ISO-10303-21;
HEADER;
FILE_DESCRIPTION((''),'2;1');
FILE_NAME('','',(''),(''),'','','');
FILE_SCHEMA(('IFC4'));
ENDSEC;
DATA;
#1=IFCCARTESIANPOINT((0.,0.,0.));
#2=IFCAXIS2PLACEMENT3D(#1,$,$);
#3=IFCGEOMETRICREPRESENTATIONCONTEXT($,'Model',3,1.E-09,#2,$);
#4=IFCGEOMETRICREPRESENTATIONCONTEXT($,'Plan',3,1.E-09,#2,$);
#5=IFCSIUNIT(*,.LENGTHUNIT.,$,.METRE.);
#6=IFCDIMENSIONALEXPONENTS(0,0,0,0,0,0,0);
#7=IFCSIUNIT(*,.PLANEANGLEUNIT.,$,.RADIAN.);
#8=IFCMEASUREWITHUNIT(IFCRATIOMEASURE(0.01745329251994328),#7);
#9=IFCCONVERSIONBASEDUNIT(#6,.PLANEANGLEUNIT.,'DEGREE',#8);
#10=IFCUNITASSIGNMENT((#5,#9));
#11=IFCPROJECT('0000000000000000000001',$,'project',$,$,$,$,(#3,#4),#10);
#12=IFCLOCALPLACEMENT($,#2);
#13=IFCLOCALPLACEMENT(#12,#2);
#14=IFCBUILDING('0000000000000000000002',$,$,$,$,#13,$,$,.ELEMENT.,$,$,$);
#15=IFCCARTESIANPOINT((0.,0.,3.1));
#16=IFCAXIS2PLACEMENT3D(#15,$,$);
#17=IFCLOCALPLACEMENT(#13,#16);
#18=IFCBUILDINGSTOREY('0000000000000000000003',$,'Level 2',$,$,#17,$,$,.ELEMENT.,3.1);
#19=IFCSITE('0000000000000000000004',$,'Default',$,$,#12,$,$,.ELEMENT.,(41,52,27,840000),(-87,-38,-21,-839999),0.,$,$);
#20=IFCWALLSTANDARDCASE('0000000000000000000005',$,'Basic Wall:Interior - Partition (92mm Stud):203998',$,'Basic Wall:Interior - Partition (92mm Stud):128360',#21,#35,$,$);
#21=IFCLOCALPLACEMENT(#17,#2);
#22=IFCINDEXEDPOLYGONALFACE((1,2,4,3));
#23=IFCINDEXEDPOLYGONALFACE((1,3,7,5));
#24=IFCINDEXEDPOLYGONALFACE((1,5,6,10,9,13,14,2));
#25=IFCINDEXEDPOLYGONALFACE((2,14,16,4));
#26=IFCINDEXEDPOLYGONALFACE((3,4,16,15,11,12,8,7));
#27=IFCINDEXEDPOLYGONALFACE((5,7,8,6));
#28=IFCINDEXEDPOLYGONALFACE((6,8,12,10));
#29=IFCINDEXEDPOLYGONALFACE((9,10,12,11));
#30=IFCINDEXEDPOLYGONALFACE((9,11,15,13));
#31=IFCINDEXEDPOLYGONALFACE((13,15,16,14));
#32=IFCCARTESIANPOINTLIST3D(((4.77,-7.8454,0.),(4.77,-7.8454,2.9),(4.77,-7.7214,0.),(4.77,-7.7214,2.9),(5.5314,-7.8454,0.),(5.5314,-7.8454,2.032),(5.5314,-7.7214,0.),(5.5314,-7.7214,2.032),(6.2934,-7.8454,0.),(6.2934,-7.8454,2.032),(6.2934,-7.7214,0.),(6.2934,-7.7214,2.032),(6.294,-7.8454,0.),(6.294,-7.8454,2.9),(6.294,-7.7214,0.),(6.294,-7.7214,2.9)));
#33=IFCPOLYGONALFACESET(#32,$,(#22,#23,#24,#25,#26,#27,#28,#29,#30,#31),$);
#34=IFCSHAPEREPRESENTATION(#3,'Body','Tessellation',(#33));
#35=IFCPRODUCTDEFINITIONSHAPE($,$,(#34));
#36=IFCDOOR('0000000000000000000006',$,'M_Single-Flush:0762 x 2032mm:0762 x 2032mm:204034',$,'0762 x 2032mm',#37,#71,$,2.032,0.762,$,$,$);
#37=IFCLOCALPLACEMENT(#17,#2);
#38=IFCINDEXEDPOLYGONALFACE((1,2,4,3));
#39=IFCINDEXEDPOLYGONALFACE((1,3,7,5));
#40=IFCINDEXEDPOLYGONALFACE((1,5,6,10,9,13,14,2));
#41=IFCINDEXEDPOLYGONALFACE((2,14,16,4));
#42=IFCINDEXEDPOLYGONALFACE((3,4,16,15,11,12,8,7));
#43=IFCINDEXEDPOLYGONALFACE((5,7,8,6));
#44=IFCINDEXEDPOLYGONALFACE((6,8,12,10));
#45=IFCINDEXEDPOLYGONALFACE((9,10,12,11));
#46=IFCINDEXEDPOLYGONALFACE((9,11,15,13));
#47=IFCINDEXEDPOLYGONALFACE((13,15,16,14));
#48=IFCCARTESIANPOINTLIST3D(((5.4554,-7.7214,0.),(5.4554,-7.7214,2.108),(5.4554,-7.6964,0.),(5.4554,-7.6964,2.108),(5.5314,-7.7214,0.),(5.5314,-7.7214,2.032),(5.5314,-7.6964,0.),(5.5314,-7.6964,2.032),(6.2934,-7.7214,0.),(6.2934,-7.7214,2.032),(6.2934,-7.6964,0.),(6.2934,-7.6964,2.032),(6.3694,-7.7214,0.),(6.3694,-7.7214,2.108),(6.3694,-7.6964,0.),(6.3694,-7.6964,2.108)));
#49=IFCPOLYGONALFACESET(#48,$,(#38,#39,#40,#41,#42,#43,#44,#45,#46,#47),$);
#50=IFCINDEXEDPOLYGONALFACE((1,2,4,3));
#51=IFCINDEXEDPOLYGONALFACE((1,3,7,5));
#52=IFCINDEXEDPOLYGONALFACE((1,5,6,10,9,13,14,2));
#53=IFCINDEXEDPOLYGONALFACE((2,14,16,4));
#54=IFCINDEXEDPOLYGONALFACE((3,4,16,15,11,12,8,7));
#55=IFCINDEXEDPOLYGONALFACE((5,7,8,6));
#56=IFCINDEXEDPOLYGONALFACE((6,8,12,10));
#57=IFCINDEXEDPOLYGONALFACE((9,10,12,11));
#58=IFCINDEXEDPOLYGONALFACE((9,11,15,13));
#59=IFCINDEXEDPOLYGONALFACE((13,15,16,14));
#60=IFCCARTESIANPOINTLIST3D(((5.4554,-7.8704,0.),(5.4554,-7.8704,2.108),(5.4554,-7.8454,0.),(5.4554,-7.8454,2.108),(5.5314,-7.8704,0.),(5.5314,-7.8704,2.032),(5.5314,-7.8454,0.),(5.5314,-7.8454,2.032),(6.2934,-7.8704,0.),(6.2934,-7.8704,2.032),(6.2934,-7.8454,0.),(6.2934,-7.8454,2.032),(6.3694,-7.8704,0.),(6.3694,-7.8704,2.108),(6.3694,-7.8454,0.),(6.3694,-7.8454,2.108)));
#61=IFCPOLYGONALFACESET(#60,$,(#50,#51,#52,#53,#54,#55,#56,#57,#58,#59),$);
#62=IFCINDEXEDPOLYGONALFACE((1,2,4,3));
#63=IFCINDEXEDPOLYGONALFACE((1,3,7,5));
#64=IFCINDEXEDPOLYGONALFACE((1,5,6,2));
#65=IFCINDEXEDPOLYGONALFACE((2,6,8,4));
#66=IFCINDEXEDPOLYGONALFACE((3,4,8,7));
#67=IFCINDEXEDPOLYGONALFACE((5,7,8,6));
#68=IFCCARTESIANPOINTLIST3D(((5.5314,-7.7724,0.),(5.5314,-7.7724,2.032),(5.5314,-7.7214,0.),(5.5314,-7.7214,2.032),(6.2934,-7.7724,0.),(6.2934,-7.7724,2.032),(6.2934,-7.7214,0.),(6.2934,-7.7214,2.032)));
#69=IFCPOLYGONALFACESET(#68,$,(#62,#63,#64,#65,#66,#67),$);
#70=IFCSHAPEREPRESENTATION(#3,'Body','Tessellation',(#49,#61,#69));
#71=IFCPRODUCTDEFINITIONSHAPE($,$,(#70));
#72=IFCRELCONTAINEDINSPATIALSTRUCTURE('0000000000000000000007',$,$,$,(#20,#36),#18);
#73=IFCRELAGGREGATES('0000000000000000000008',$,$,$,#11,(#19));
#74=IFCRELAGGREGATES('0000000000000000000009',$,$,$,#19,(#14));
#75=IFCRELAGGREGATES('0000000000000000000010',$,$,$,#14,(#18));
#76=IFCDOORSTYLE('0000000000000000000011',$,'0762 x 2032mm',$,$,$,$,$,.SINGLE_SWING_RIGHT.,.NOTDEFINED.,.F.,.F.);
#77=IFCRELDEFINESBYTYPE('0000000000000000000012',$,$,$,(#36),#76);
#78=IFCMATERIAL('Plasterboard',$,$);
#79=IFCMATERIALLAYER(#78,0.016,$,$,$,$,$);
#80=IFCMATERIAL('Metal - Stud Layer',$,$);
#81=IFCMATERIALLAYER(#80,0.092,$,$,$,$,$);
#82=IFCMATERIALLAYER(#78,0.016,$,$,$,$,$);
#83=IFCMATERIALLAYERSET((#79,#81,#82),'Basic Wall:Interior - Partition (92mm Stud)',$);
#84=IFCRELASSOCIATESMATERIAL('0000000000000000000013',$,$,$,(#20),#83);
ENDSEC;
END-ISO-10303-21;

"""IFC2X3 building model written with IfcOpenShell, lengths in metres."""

from ifc_helpers import new_model, entity, si_unit, converted_unit, frame, frame_2d, origin, origin_2d_with_axis, place, context, project, spatial, polyline, rectangle, outline, extrude, source, transform, mapped, material, layer, layer_set, layer_usage, type_object, type_shapes, element, fill, save


model = new_model("IFC2X3")

# Units and contexts
model_context = context("Model", 3, precision=1e-09, world=origin())
plan_context = context("Plan", 3, precision=1e-09, world=origin())
ifc_project = project(units=[si_unit("LENGTHUNIT", "METRE"), converted_unit("PLANEANGLEUNIT", "DEGREE", entity("IfcRatioMeasure", 0.01745329251994328), si_unit("PLANEANGLEUNIT", "RADIAN"), dimensions=[0, 0, 0, 0, 0, 0, 0])], contexts=[model_context, plan_context])

# Site, building, storey
site_placement = place(None, origin())
site = spatial("IfcSite", under=ifc_project, at=site_placement, Name="Default", CompositionType="ELEMENT", RefLatitude=(41, 52, 27, 840000), RefLongitude=(-87, -38, -21, -839999), RefElevation=0.0)
building_placement = place(site_placement, origin())
building = spatial("IfcBuilding", under=site, at=building_placement, CompositionType="ELEMENT")
storey_placement = place(building_placement, frame((0.0, 0.0, 3.1)))
storey = spatial("IfcBuildingStorey", under=building, at=storey_placement, Name="Level 2", CompositionType="ELEMENT", Elevation=3.1)

# Wall, opening, door
ifc_material_1 = material(Name="Plasterboard")
ifc_layer_1 = layer(ifc_material_1, 0.016)
ifc_material_2 = material(Name="Metal - Stud Layer")
ifc_layer_2 = layer(ifc_material_2, 0.092)
ifc_layer_3 = layer(ifc_material_1, 0.016)
ifc_layer_set = layer_set([ifc_layer_1, ifc_layer_2, ifc_layer_3], Name="Basic Wall:Interior - Partition (92mm Stud)")
ifc_layer_usage = layer_usage(ifc_layer_set, "AXIS2", "POSITIVE", -0.062)
wall_placement = place(storey_placement, frame((4.77, -7.7834, 0.0)))
wall = element("IfcWallStandardCase", 1, at=wall_placement, inside=storey, material=ifc_layer_usage, Name="Basic Wall:Interior - Partition (92mm Stud):203998", ObjectType="Basic Wall:Interior - Partition (92mm Stud):128360", context=model_context, shape_type="SweptSolid", body=[
    extrude(rectangle(XDim=1.524, YDim=0.124, at=frame_2d((0.762, 0.0), x_axis=(-1.0, 0.0))), origin(), (0.0, 0.0, 1.0), 2.9),
])
opening_placement = place(wall_placement, frame((0.7614, -0.062, 0.0)))
opening = element("IfcOpeningElement", 2, at=opening_placement, cuts=wall, ObjectType="Opening", context=model_context, shape_type="SweptSolid", body=[
    extrude(rectangle(XDim=0.762, YDim=2.032, at=frame_2d((1.016, 0.381), x_axis=(0.0, 1.0))), frame((0.0, 0.0, 0.0), z_axis=(0.0, 1.0, 0.0), x_axis=(0.0, 0.0, 1.0)), (0.0, 0.0, 1.0), 0.124),
])
door_style = type_object("IfcDoorStyle", Name="0762 x 2032mm", ConstructionType="NOTDEFINED", OperationType="SINGLE_SWING_RIGHT", ParameterTakesPrecedence=False, Sizeable=False)
shared_shape = source(origin(), model_context, "Body", "SweptSolid", [
    extrude(outline(polyline([(-0.457, -1.073), (0.457, -1.073), (0.457, 1.035), (0.381, 1.035), (0.381, -0.997), (-0.381, -0.997), (-0.381, 1.035), (-0.457, 1.035), (-0.457, -1.073)])), frame((0.381, 0.124, 1.035), z_axis=(0.0, 1.0, 0.0), x_axis=(1.0, 0.0, 0.0)), (0.0, 0.0, 1.0), 0.025),
    extrude(outline(polyline([(-1.073, -0.457), (1.035, -0.457), (1.035, -0.381), (-0.997, -0.381), (-0.997, 0.381), (1.035, 0.381), (1.035, 0.457), (-1.073, 0.457), (-1.073, -0.457)])), frame((0.381, -0.025, 1.035), z_axis=(0.0, 1.0, 0.0), x_axis=(0.0, 0.0, -1.0)), (0.0, 0.0, 1.0), 0.025),
    extrude(rectangle(XDim=0.051, YDim=0.762, at=origin_2d_with_axis()), frame((0.381, 0.0985, 0.0), z_axis=(0.0, 0.0, 1.0), x_axis=(0.0, 1.0, 0.0)), (0.0, 0.0, 1.0), 2.032),
])
type_shapes(door_style, [shared_shape])
door_placement = place(opening_placement, origin())
door = element("IfcDoor", 3, at=door_placement, inside=storey, type_object=door_style, Name="M_Single-Flush:0762 x 2032mm:0762 x 2032mm:204034", ObjectType="0762 x 2032mm", OverallHeight=2.032, OverallWidth=0.762, context=model_context, shape_type="MappedRepresentation", body=[
    mapped(shared_shape, transform((0.0, 0.0, 0.0), scale=1.0)),
])
fill(opening, door)

save(model, "model.ifc")
